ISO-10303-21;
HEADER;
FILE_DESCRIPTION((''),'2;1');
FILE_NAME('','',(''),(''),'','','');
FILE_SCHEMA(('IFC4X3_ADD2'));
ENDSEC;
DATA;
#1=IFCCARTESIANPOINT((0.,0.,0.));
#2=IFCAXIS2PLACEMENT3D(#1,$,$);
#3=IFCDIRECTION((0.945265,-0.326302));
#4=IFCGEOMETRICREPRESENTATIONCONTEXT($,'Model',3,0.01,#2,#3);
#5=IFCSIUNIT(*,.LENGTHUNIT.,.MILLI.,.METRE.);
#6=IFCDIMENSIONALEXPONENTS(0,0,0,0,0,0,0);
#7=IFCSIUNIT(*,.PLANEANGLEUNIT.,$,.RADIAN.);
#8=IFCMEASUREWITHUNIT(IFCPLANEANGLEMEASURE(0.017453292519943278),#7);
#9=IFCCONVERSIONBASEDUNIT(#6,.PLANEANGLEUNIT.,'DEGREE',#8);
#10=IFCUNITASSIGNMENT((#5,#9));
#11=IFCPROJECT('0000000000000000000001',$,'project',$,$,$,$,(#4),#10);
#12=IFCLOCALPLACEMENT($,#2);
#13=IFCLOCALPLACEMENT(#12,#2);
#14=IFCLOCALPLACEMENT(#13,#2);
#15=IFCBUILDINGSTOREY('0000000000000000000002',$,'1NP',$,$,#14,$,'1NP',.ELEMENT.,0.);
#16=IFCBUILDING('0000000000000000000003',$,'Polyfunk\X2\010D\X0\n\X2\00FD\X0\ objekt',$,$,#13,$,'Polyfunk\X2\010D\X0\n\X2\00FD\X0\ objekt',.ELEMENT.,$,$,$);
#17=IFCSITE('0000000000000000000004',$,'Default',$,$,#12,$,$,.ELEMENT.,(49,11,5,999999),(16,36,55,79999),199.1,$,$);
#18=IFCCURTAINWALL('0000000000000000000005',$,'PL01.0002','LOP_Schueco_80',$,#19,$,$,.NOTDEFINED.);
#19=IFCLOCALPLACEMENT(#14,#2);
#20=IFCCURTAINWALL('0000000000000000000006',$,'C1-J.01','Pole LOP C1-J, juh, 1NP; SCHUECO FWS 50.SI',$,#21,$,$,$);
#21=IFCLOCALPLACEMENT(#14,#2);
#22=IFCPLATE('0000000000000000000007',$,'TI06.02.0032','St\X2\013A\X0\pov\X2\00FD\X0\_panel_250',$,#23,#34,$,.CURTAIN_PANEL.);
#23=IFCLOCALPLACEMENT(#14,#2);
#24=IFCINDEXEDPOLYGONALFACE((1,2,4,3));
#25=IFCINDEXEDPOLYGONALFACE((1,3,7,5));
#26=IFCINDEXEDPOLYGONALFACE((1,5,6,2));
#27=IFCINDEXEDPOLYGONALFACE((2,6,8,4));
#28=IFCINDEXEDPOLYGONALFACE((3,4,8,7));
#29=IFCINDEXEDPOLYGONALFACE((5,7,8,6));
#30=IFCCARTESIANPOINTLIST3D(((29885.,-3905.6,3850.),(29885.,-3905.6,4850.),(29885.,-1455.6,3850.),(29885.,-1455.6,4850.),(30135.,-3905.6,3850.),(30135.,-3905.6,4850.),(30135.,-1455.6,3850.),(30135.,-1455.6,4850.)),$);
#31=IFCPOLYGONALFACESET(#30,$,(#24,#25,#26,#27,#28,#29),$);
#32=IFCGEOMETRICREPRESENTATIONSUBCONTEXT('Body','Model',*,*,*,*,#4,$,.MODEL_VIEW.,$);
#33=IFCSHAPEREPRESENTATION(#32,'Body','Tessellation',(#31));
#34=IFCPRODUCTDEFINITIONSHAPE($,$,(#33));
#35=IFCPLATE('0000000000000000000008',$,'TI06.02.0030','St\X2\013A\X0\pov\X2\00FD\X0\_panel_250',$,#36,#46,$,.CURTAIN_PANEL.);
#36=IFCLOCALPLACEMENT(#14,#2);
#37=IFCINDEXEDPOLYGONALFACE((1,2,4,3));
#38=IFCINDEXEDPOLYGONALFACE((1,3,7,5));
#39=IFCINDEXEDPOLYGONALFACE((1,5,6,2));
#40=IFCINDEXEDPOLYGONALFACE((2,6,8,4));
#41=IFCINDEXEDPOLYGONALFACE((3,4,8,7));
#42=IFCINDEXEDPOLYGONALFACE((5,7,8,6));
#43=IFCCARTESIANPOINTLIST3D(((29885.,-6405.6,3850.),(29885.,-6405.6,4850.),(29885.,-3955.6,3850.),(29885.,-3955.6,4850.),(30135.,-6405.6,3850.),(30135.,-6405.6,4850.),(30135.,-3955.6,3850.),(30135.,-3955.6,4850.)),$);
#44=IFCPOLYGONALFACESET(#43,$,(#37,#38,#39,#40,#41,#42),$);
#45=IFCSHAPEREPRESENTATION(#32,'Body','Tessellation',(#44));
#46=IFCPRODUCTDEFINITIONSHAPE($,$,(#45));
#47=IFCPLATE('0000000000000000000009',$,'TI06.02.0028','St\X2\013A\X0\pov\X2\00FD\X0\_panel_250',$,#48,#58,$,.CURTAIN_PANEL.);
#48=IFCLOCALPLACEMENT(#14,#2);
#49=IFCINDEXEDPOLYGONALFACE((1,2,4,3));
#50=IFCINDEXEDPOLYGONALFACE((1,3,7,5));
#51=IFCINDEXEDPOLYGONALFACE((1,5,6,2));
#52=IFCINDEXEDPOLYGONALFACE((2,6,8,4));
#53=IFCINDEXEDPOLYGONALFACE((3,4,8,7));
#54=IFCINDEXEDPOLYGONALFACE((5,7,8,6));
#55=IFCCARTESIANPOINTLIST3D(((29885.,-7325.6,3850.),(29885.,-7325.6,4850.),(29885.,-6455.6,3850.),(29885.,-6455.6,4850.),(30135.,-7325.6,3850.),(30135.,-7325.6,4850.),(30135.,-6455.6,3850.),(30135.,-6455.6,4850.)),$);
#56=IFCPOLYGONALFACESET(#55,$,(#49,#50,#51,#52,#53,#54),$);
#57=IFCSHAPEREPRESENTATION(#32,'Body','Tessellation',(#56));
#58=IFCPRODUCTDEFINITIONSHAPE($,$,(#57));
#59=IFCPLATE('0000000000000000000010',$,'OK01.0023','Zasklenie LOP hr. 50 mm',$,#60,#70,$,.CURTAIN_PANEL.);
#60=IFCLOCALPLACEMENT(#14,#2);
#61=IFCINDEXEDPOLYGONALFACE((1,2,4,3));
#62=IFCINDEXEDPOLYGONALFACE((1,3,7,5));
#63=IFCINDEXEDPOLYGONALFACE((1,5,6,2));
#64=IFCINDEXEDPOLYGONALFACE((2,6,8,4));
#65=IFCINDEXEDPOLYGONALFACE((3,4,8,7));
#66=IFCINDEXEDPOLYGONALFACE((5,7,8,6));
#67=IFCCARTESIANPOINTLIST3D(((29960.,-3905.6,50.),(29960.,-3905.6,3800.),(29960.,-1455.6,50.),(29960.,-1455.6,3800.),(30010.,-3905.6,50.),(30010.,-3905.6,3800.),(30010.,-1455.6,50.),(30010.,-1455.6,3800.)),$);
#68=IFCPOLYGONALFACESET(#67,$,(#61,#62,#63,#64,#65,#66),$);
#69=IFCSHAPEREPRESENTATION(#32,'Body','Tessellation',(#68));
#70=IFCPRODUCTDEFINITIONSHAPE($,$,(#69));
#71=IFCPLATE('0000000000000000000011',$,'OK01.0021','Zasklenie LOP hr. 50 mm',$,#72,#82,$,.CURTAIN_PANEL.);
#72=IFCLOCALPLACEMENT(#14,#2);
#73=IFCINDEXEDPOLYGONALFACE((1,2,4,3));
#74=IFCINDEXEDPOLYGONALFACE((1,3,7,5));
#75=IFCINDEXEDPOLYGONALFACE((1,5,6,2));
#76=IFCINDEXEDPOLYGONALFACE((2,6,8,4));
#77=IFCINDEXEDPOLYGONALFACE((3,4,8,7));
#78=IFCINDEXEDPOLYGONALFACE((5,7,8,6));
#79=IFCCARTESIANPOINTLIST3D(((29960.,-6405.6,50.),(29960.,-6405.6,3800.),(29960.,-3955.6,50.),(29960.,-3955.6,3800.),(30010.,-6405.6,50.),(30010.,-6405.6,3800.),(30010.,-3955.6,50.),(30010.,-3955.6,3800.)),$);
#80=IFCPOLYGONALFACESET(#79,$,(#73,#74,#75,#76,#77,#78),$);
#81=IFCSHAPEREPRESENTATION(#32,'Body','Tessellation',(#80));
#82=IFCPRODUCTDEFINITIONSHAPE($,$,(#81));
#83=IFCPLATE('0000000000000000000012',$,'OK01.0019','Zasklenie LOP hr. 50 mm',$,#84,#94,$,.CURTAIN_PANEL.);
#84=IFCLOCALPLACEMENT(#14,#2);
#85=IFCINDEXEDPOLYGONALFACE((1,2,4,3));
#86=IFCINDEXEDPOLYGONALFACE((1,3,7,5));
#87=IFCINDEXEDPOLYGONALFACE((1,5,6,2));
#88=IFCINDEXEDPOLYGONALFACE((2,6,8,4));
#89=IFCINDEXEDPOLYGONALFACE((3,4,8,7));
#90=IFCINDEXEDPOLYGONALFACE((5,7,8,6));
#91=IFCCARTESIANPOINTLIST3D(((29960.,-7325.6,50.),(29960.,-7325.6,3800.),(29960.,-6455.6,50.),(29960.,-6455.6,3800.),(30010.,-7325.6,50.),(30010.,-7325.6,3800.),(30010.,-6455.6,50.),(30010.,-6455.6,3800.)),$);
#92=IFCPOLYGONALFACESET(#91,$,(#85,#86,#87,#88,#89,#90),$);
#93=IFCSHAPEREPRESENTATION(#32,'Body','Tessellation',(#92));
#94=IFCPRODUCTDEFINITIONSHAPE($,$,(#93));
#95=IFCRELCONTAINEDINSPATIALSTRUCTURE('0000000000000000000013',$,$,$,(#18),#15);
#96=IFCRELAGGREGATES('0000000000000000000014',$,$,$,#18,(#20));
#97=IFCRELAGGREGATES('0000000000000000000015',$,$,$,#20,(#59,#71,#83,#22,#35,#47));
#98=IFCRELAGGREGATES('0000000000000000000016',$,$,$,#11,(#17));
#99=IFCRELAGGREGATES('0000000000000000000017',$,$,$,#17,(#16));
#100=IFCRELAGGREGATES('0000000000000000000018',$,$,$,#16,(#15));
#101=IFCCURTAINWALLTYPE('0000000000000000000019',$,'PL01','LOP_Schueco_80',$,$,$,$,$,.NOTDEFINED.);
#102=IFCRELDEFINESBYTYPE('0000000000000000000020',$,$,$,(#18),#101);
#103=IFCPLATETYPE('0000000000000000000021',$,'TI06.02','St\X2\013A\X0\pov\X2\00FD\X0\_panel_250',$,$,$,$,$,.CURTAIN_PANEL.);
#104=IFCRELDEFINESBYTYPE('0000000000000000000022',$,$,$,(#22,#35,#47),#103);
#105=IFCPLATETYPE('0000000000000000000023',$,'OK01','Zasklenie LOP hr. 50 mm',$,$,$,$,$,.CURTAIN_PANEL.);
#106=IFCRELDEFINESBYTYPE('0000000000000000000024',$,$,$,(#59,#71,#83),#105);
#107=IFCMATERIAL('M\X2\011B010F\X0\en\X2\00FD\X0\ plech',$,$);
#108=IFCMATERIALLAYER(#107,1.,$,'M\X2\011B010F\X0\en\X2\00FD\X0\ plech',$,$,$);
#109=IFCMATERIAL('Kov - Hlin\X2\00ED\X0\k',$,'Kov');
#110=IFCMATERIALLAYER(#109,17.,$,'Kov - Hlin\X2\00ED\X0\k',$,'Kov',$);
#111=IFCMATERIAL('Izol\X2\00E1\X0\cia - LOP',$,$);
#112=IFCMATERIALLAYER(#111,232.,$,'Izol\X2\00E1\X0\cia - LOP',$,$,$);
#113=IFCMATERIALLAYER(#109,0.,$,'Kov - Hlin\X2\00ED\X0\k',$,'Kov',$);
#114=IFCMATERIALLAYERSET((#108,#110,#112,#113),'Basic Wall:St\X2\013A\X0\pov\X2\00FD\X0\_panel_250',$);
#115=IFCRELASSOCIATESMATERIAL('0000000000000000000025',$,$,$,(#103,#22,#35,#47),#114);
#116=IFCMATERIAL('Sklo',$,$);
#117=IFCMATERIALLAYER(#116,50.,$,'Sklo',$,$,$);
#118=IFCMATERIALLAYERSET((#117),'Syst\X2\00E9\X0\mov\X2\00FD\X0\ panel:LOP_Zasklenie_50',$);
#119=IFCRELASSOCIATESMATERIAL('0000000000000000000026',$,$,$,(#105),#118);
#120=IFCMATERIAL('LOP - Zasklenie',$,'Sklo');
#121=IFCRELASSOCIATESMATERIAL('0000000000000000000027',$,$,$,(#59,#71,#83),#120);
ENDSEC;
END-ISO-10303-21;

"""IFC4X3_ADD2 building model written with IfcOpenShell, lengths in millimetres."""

from ifc_helpers import new_model, entity, si_unit, converted_unit, direction, frame, frame_2d, origin, origin_2d_with_axis, place, context, subcontext, project, spatial, rectangle, extrude, source, transform, mapped, material, layer, layer_set, layer_usage, type_object, type_shapes, element, aggregate, save


model = new_model("IFC4X3_ADD2")

# Units and contexts
model_context = context("Model", 3, precision=0.01, world=origin(), true_north=direction((0.945265, -0.326302)))
body_context = subcontext(model_context, "Body", "Model", "MODEL_VIEW")
ifc_project = project(units=[si_unit("LENGTHUNIT", "METRE", prefix="MILLI"), converted_unit("PLANEANGLEUNIT", "DEGREE", entity("IfcPlaneAngleMeasure", 0.017453292519943278), si_unit("PLANEANGLEUNIT", "RADIAN"), dimensions=[0, 0, 0, 0, 0, 0, 0])], contexts=[model_context])

# Site, building, storey
site_placement = place(None, origin())
site = spatial("IfcSite", under=ifc_project, at=site_placement, Name="Default", CompositionType="ELEMENT", RefLatitude=(49, 11, 5, 999999), RefLongitude=(16, 36, 55, 79999), RefElevation=199.1)
building_placement = place(site_placement, origin())
building = spatial("IfcBuilding", under=site, at=building_placement, Name="Polyfunkčný objekt", LongName="Polyfunkčný objekt", CompositionType="ELEMENT")
storey_placement = place(building_placement, origin())
storey = spatial("IfcBuildingStorey", under=building, at=storey_placement, Name="1NP", LongName="1NP", CompositionType="ELEMENT", Elevation=0.0)

# Curtain walls
curtain_wall_type = type_object("IfcCurtainWallType", Name="PL01", Description="LOP_Schueco_80", PredefinedType="NOTDEFINED")
curtain_wall_1_placement = place(storey_placement, origin())
curtain_wall_1 = element("IfcCurtainWall", 1, at=curtain_wall_1_placement, inside=storey, type_object=curtain_wall_type, Name="PL01.0002", Description="LOP_Schueco_80", PredefinedType="NOTDEFINED")
curtain_wall_2 = element("IfcCurtainWall", 2, Name="C1-J.01", Description="Pole LOP C1-J, juh, 1NP; SCHUECO FWS 50.SI")
aggregate(curtain_wall_1, [curtain_wall_2])

# Plates
ifc_material_1 = material(Name="Měďený plech")
ifc_layer_1 = layer(ifc_material_1, 1.0, Name="Měďený plech")
ifc_material_2 = material(Name="Kov - Hliník", Category="Kov")
ifc_layer_2 = layer(ifc_material_2, 17.0, Name="Kov - Hliník", Category="Kov")
ifc_material_3 = material(Name="Izolácia - LOP")
ifc_layer_3 = layer(ifc_material_3, 232.0, Name="Izolácia - LOP")
ifc_layer_4 = layer(ifc_material_2, 0.0, Name="Kov - Hliník", Category="Kov")
ifc_layer_set_1 = layer_set([ifc_layer_1, ifc_layer_2, ifc_layer_3, ifc_layer_4], Name="Basic Wall:Stĺpový_panel_250")
plate_type_1 = type_object("IfcPlateType", Name="TI06.02", Description="Stĺpový_panel_250", PredefinedType="CURTAIN_PANEL", material=ifc_layer_set_1)
ifc_layer_usage_1 = layer_usage(ifc_layer_set_1, "AXIS2", "POSITIVE", -125.0)
plate_1_placement = place(storey_placement, frame((30010.0, -1455.6, 3850.0), z_axis=(0.0, 0.0, 1.0), x_axis=(0.0, -1.0, 0.0)))
plate_1 = element("IfcPlate", 3, at=plate_1_placement, type_object=plate_type_1, material=ifc_layer_usage_1, Name="TI06.02.0032", Description="Stĺpový_panel_250", PredefinedType="CURTAIN_PANEL", context=body_context, shape_type="SweptSolid", body=[
    extrude(rectangle(XDim=250.0, YDim=2450.0, at=frame_2d((0.0, 0.0), x_axis=(1.0, 0.0))), frame((1225.0, 0.0, 0.0), z_axis=(0.0, 0.0, 1.0), x_axis=(0.0, 1.0, 0.0)), (0.0, 0.0, 1.0), 1000.0),
])
ifc_layer_usage_2 = layer_usage(ifc_layer_set_1, "AXIS2", "POSITIVE", -125.0)
plate_2_placement = place(storey_placement, frame((30010.0, -3955.6, 3850.0), z_axis=(0.0, 0.0, 1.0), x_axis=(0.0, -1.0, 0.0)))
plate_2 = element("IfcPlate", 4, at=plate_2_placement, type_object=plate_type_1, material=ifc_layer_usage_2, Name="TI06.02.0030", Description="Stĺpový_panel_250", PredefinedType="CURTAIN_PANEL", context=body_context, shape_type="SweptSolid", body=[
    extrude(rectangle(XDim=250.0, YDim=2450.0, at=origin_2d_with_axis()), frame((1225.0, 0.0, 0.0), z_axis=(0.0, 0.0, 1.0), x_axis=(0.0, 1.0, 0.0)), (0.0, 0.0, 1.0), 1000.0),
])
ifc_layer_usage_3 = layer_usage(ifc_layer_set_1, "AXIS2", "POSITIVE", -125.0)
plate_3_placement = place(storey_placement, frame((30010.0, -6455.6, 3850.0), z_axis=(0.0, 0.0, 1.0), x_axis=(0.0, -1.0, 0.0)))
plate_3 = element("IfcPlate", 5, at=plate_3_placement, type_object=plate_type_1, material=ifc_layer_usage_3, Name="TI06.02.0028", Description="Stĺpový_panel_250", PredefinedType="CURTAIN_PANEL", context=body_context, shape_type="SweptSolid", body=[
    extrude(rectangle(XDim=250.0, YDim=870.0, at=frame_2d((0.0, 0.0), x_axis=(1.0, 0.0))), frame((435.0, 0.0, 0.0), z_axis=(0.0, 0.0, 1.0), x_axis=(0.0, 1.0, 0.0)), (0.0, 0.0, 1.0), 1000.0),
])
ifc_material_4 = material(Name="LOP - Zasklenie", Category="Sklo")
ifc_material_5 = material(Name="Sklo")
ifc_layer_5 = layer(ifc_material_5, 50.0, Name="Sklo")
ifc_layer_set_2 = layer_set([ifc_layer_5], Name="Systémový panel:LOP_Zasklenie_50")
plate_type_2 = type_object("IfcPlateType", Name="OK01", Description="Zasklenie LOP hr. 50 mm", PredefinedType="CURTAIN_PANEL", material=ifc_layer_set_2)
shared_shape_1 = source(origin(), body_context, "Body", "SweptSolid", [
    extrude(rectangle(XDim=3750.0, YDim=2450.0, at=frame_2d((-141.7, 0.0), x_axis=(1.0, 0.0))), frame((0.0, -50.0, 2016.7), z_axis=(0.0, 1.0, 0.0), x_axis=(0.0, 0.0, 1.0)), (0.0, 0.0, 1.0), 50.0),
])
plate_4_placement = place(curtain_wall_1_placement, frame((30010.0, -2680.6, 50.0), z_axis=(0.0, 0.0, 1.0), x_axis=(0.0, -1.0, 0.0)))
plate_4 = element("IfcPlate", 6, at=plate_4_placement, type_object=plate_type_2, material=ifc_material_4, Name="OK01.0023", Description="Zasklenie LOP hr. 50 mm", PredefinedType="CURTAIN_PANEL", context=body_context, shape_type="MappedRepresentation", body=[
    mapped(shared_shape_1, transform((0.0, 0.0, 0.0), scale=1.0)),
])
plate_5_placement = place(curtain_wall_1_placement, frame((30010.0, -5180.6, 50.0), z_axis=(0.0, 0.0, 1.0), x_axis=(0.0, -1.0, 0.0)))
plate_5 = element("IfcPlate", 7, at=plate_5_placement, type_object=plate_type_2, material=ifc_material_4, Name="OK01.0021", Description="Zasklenie LOP hr. 50 mm", PredefinedType="CURTAIN_PANEL", context=body_context, shape_type="MappedRepresentation", body=[
    mapped(shared_shape_1, transform((0.0, 0.0, 0.0), scale=1.0)),
])
shared_shape_2 = source(origin(), body_context, "Body", "SweptSolid", [
    extrude(rectangle(XDim=3750.0, YDim=870.0, at=frame_2d((-141.7, 0.0), x_axis=(1.0, 0.0))), frame((0.0, -50.0, 2016.7), z_axis=(0.0, 1.0, 0.0), x_axis=(0.0, 0.0, 1.0)), (0.0, 0.0, 1.0), 50.0),
])
type_shapes(plate_type_2, [shared_shape_1, shared_shape_2])
plate_6_placement = place(curtain_wall_1_placement, frame((30010.0, -6890.6, 50.0), z_axis=(0.0, 0.0, 1.0), x_axis=(0.0, -1.0, 0.0)))
plate_6 = element("IfcPlate", 8, at=plate_6_placement, type_object=plate_type_2, material=ifc_material_4, Name="OK01.0019", Description="Zasklenie LOP hr. 50 mm", PredefinedType="CURTAIN_PANEL", context=body_context, shape_type="MappedRepresentation", body=[
    mapped(shared_shape_2, transform((0.0, 0.0, 0.0), scale=1.0)),
])
aggregate(curtain_wall_2, [plate_4, plate_5, plate_6, plate_1, plate_2, plate_3])

save(model, "model.ifc")
